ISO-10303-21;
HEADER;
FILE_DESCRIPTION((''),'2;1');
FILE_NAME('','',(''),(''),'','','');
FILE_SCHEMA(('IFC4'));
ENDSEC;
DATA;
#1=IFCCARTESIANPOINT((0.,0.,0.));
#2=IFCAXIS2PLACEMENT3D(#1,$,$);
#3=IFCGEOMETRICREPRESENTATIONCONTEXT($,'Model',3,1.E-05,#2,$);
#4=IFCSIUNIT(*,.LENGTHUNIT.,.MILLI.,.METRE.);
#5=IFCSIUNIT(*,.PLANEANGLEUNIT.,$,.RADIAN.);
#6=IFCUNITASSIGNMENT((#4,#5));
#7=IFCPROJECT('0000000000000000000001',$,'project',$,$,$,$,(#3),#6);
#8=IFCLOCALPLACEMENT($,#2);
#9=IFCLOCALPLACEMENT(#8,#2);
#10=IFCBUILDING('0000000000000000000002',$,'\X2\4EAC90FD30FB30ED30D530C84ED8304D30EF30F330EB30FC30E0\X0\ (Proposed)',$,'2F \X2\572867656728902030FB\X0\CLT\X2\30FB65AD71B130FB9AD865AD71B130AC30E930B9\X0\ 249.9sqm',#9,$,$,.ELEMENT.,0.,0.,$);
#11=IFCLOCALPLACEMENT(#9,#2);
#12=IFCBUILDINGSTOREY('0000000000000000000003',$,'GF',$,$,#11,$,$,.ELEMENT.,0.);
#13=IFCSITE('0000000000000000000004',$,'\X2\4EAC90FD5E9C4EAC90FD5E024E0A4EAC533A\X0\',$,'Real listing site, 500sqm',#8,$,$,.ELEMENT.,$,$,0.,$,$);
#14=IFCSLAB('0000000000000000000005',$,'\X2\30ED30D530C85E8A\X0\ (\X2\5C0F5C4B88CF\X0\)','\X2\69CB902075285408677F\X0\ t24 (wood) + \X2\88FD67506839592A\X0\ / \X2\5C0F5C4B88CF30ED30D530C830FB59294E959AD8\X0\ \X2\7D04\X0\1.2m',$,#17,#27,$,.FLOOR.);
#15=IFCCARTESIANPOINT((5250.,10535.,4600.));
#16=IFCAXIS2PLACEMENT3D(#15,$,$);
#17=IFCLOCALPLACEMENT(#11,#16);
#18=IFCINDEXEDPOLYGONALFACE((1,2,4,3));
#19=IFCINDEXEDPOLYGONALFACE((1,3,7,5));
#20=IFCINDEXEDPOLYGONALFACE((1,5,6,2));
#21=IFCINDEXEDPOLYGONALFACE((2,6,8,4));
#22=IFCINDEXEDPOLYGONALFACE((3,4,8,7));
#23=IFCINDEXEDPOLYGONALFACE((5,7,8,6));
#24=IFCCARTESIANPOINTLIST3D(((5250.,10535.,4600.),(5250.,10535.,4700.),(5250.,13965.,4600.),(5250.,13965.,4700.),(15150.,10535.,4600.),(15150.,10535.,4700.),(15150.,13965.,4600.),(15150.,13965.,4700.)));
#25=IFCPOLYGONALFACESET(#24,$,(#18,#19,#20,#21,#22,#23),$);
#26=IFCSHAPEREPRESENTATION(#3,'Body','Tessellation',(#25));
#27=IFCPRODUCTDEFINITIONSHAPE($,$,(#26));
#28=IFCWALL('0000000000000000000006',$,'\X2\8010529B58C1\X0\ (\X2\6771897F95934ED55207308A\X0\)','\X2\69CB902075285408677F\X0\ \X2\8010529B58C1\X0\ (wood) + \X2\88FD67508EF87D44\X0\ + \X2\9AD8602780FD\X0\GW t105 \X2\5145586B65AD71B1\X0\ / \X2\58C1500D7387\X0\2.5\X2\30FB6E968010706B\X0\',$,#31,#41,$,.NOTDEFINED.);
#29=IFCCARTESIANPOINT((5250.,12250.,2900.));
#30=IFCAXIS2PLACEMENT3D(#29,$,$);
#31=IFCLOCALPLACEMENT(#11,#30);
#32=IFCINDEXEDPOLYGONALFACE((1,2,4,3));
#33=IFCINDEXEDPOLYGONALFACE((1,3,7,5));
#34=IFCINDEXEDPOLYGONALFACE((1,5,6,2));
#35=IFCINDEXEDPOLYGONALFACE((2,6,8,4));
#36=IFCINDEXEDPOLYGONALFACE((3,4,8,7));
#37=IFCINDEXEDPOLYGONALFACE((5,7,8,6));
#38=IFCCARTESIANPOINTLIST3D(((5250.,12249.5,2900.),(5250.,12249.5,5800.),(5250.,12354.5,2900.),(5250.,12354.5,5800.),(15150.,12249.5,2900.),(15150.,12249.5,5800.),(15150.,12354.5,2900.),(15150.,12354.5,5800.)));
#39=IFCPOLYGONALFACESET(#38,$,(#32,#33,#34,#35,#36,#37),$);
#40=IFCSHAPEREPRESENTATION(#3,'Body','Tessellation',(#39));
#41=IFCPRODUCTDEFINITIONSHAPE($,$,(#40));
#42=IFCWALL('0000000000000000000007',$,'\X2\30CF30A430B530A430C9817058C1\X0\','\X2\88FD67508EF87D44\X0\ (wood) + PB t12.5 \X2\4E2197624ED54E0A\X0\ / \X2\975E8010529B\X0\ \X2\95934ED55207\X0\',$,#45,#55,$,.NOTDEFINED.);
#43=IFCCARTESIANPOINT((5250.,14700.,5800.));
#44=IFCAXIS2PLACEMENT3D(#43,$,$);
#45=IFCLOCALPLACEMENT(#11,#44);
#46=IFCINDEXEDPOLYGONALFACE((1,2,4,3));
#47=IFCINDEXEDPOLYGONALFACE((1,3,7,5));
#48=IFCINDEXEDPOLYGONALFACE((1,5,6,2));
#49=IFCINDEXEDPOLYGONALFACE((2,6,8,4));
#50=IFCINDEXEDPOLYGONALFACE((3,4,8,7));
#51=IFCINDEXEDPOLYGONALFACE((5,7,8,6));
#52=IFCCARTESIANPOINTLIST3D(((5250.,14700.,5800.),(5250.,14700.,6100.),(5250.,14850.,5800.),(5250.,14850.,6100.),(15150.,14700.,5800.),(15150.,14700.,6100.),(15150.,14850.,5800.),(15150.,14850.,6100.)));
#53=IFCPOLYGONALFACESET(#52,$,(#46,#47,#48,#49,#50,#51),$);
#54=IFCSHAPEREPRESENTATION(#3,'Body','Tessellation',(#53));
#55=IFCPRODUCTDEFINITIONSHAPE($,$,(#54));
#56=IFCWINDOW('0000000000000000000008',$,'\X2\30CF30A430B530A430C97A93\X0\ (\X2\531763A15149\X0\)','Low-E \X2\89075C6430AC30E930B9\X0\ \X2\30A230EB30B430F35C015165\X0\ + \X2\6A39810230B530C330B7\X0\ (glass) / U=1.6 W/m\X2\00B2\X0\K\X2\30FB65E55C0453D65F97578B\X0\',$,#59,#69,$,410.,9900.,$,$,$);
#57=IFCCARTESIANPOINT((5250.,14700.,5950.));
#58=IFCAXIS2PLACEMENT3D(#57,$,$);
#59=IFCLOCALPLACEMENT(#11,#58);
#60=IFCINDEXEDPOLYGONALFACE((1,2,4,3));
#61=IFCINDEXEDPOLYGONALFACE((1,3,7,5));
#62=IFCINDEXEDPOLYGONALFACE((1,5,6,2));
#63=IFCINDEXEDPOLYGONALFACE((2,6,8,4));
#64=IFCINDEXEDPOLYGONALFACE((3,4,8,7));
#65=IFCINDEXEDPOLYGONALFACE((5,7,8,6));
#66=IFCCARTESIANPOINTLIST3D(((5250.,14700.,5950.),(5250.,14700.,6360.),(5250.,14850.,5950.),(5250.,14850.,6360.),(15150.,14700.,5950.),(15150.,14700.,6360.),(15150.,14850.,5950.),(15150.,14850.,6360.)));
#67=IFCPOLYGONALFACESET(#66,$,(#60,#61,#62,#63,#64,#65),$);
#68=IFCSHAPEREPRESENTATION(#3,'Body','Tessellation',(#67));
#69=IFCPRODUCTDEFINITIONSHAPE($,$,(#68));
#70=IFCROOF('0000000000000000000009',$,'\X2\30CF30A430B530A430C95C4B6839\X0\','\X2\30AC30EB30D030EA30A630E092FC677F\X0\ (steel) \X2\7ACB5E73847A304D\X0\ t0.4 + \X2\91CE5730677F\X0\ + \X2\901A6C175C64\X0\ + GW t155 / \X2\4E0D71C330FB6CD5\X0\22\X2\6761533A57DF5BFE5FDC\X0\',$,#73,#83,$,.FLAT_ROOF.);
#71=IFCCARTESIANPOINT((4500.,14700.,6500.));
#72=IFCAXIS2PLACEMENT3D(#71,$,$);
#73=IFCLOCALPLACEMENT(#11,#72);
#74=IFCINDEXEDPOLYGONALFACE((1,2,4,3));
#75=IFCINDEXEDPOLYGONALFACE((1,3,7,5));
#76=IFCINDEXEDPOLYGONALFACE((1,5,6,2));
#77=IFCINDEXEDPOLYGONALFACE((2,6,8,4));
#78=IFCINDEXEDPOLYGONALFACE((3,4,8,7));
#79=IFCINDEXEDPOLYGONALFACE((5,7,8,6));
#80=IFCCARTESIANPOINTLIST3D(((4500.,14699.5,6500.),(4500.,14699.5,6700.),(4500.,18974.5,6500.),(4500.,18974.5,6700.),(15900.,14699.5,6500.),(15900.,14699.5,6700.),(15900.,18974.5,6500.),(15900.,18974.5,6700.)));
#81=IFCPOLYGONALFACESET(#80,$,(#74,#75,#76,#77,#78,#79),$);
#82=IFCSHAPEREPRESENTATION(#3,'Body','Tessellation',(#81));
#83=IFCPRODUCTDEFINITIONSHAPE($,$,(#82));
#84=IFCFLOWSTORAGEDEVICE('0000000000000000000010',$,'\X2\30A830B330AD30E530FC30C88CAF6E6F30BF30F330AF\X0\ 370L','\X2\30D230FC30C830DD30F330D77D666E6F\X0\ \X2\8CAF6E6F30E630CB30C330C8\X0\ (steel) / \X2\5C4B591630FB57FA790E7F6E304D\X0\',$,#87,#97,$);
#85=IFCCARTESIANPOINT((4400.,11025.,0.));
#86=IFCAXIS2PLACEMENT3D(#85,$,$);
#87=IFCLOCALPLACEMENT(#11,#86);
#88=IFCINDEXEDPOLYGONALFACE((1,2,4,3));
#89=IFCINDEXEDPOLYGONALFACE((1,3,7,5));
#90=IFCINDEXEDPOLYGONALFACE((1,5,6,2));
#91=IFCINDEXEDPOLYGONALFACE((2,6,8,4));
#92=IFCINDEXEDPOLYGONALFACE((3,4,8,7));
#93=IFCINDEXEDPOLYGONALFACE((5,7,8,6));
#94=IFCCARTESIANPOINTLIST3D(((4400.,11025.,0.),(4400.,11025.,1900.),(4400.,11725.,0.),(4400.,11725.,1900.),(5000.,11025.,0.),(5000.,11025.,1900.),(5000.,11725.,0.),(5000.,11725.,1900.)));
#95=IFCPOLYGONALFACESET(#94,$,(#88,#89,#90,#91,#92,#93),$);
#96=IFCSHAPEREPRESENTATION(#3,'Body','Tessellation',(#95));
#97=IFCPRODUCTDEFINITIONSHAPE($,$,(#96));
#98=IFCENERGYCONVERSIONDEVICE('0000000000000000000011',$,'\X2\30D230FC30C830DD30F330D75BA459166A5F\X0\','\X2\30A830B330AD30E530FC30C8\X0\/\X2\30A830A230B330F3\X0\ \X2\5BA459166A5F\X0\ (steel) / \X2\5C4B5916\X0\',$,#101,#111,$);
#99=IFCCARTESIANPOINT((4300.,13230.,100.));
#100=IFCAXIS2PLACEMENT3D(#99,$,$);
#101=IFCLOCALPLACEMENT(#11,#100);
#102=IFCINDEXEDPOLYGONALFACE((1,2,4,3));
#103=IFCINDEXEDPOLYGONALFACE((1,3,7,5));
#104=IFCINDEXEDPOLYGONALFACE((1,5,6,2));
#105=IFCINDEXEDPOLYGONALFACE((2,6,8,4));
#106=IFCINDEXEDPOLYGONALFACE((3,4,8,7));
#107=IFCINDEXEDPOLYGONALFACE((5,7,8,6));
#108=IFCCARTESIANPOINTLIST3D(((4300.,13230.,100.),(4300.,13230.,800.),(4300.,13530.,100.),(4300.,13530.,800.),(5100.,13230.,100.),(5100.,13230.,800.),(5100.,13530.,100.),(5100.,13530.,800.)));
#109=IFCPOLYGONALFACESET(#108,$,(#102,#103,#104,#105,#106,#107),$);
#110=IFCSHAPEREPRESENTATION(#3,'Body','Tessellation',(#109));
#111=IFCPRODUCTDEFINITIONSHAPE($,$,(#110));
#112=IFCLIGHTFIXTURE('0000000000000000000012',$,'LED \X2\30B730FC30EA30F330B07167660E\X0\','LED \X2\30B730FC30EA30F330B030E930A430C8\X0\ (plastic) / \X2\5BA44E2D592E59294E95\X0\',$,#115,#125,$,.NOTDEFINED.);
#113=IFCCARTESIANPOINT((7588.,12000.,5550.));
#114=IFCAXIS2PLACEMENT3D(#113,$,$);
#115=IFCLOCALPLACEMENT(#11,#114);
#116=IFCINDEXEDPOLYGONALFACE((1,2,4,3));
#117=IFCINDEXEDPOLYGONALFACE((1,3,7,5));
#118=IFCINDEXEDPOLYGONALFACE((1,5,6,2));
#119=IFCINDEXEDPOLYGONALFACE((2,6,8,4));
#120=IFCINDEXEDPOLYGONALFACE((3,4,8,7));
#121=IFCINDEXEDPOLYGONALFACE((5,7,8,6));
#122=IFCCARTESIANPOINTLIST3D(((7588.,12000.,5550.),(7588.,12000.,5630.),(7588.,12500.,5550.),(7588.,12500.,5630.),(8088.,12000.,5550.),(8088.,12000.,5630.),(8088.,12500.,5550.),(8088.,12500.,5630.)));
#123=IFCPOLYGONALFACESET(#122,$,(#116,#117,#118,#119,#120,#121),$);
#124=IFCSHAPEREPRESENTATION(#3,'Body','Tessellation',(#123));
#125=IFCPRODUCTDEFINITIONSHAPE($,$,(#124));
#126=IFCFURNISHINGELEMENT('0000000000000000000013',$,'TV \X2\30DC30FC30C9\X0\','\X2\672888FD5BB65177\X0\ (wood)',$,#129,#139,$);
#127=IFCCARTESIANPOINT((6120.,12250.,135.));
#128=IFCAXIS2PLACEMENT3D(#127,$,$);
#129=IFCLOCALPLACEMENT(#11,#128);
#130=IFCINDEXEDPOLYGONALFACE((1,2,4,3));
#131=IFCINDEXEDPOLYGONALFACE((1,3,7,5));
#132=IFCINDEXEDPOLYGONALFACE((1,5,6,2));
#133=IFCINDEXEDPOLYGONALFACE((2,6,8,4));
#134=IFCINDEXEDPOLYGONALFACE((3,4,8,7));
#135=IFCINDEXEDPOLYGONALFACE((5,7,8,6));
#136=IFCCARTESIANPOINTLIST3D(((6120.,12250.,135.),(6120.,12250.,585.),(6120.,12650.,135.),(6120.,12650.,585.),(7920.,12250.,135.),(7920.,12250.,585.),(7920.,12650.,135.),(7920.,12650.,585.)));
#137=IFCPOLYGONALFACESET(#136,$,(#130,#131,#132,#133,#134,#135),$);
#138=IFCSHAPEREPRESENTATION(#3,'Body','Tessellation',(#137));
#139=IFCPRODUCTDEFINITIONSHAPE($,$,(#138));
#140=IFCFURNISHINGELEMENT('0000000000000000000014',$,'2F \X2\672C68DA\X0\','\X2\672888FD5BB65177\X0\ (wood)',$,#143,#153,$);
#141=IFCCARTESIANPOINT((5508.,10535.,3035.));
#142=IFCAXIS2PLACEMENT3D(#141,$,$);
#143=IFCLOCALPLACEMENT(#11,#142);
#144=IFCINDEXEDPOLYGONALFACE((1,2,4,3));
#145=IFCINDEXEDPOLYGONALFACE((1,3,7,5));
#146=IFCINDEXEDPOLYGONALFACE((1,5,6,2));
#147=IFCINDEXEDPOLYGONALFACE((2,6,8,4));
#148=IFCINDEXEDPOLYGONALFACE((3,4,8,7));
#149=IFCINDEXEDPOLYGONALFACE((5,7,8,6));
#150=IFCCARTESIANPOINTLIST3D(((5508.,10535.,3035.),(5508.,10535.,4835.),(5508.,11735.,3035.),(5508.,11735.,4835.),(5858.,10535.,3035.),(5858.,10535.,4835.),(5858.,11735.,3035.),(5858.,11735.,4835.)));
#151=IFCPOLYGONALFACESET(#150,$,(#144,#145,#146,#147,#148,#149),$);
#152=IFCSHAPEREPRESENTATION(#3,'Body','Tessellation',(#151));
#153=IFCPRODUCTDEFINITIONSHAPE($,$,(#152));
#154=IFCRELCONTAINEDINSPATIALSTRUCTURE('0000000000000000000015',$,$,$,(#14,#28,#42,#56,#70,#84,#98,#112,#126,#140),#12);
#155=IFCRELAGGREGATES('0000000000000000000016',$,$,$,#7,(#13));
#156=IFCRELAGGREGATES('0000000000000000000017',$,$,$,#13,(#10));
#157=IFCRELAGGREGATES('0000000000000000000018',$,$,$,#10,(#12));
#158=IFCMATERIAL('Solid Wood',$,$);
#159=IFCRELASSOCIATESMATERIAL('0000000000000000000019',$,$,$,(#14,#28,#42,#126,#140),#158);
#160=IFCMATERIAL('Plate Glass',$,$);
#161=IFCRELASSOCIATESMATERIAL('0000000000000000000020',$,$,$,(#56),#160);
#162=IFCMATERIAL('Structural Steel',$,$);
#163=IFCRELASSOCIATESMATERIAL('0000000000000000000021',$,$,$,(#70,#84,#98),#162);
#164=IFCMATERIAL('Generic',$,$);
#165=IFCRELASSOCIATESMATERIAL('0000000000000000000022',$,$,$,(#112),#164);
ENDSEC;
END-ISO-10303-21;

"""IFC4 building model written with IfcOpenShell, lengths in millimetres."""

from ifc_helpers import new_model, si_unit, frame, frame_2d, origin, place, context, project, spatial, rectangle, extrude, material, element, fill, save


model = new_model("IFC4")

# Units and contexts
model_context = context("Model", 3, precision=1e-05, world=origin())
ifc_project = project(units=[si_unit("LENGTHUNIT", "METRE", prefix="MILLI"), si_unit("PLANEANGLEUNIT", "RADIAN")], contexts=[model_context])

# Site, building, storey
site_placement = place(None, origin())
site = spatial("IfcSite", under=ifc_project, at=site_placement, Name="京都府京都市上京区", ObjectType="Real listing site, 500sqm", CompositionType="ELEMENT", RefElevation=0.0)
building_placement = place(site_placement, origin())
building = spatial("IfcBuilding", under=site, at=building_placement, Name="京都・ロフト付きワンルーム (Proposed)", ObjectType="2F 在来木造・CLT・断熱・高断熱ガラス 249.9sqm", CompositionType="ELEMENT", ElevationOfRefHeight=0.0, ElevationOfTerrain=0.0)
storey_placement = place(building_placement, origin())
storey = spatial("IfcBuildingStorey", under=building, at=storey_placement, Name="GF", CompositionType="ELEMENT", Elevation=0.0)

# Shared definitions
ifc_material_1 = material(Name="Solid Wood")

# Slab
slab_placement = place(storey_placement, frame((5250.0, 10535.0, 4600.0)))
element("IfcSlab", 1, at=slab_placement, inside=storey, material=ifc_material_1, Name="ロフト床 (小屋裏)", Description="構造用合板 t24 (wood) + 製材根太 / 小屋裏ロフト・天井高 約1.2m", PredefinedType="FLOOR", context=model_context, shape_type="SweptSolid", body=[
    extrude(rectangle(XDim=9900.0, YDim=3430.0, at=frame_2d((4950.0, 1715.0))), frame((5250.0, 10535.0, 4600.0)), (0.0, 0.0, 1.0), 100.0),
])

# Wall
wall_1_placement = place(storey_placement, frame((5250.0, 12250.0, 2900.0)))
element("IfcWall", 2, at=wall_1_placement, inside=storey, material=ifc_material_1, Name="耐力壁 (東西間仕切り)", Description="構造用合板 耐力壁 (wood) + 製材軸組 + 高性能GW t105 充填断熱 / 壁倍率2.5・準耐火", PredefinedType="NOTDEFINED", context=model_context, shape_type="SweptSolid", body=[
    extrude(rectangle(XDim=9900.0, YDim=105.0, at=frame_2d((4950.0, 52.0))), frame((5250.0, 12250.0, 2900.0)), (0.0, 0.0, 1.0), 2900.0),
])

# Wall, opening, window
wall_2_placement = place(storey_placement, frame((5250.0, 14700.0, 5800.0)))
wall_2 = element("IfcWall", 3, at=wall_2_placement, inside=storey, material=ifc_material_1, Name="ハイサイド腰壁", Description="製材軸組 (wood) + PB t12.5 両面仕上 / 非耐力 間仕切", PredefinedType="NOTDEFINED", context=model_context, shape_type="SweptSolid", body=[
    extrude(rectangle(XDim=9900.0, YDim=150.0, at=frame_2d((4950.0, 75.0))), frame((5250.0, 14700.0, 5800.0)), (0.0, 0.0, 1.0), 700.0),
])
opening_1_placement = place(storey_placement, frame((5250.0, 14700.0, 5950.0)))
opening_1 = element("IfcOpeningElement", 4, at=opening_1_placement, cuts=wall_2, PredefinedType="NOTDEFINED", context=model_context, shape_type="SweptSolid", body=[
    extrude(rectangle(XDim=9900.0, YDim=150.0, at=frame_2d((4950.0, 75.0))), frame((5250.0, 14700.0, 5950.0)), (0.0, 0.0, 1.0), 410.0),
])
ifc_material_2 = material(Name="Plate Glass")
window_placement = place(storey_placement, frame((5250.0, 14700.0, 5950.0)))
window = element("IfcWindow", 5, at=window_placement, inside=storey, material=ifc_material_2, Name="ハイサイド窓 (北採光)", Description="Low-E 複層ガラス アルゴン封入 + 樹脂サッシ (glass) / U=1.6 W/m²K・日射取得型", OverallHeight=410.0, OverallWidth=9900.0, context=model_context, shape_type="SweptSolid", body=[
    extrude(rectangle(XDim=9900.0, YDim=150.0, at=frame_2d((4950.0, 75.0))), frame((5250.0, 14700.0, 5950.0)), (0.0, 0.0, 1.0), 410.0),
])
fill(opening_1, window)

# Roof
ifc_material_3 = material(Name="Structural Steel")
roof_placement = place(storey_placement, frame((4500.0, 14700.0, 6500.0)))
element("IfcRoof", 6, at=roof_placement, inside=storey, material=ifc_material_3, Name="ハイサイド屋根", Description="ガルバリウム鋼板 (steel) 立平葺き t0.4 + 野地板 + 通気層 + GW t155 / 不燃・法22条区域対応", PredefinedType="FLAT_ROOF", context=model_context, shape_type="SweptSolid", body=[
    extrude(rectangle(XDim=11400.0, YDim=4275.0, at=frame_2d((5700.0, 2137.0))), frame((4500.0, 14700.0, 6500.0)), (0.0, 0.0, 1.0), 200.0),
])

# Flow storage device
flow_storage_device_placement = place(storey_placement, frame((4400.0, 11025.0, 0.0)))
element("IfcFlowStorageDevice", 7, at=flow_storage_device_placement, inside=storey, material=ifc_material_3, Name="エコキュート貯湯タンク 370L", Description="ヒートポンプ給湯 貯湯ユニット (steel) / 屋外・基礎置き", context=model_context, shape_type="SweptSolid", body=[
    extrude(rectangle(XDim=600.0, YDim=700.0, at=frame_2d((300.0, 350.0))), frame((4400.0, 11025.0, 0.0)), (0.0, 0.0, 1.0), 1900.0),
])

# Energy conversion device
energy_conversion_device_placement = place(storey_placement, frame((4300.0, 13230.0, 100.0)))
element("IfcEnergyConversionDevice", 8, at=energy_conversion_device_placement, inside=storey, material=ifc_material_3, Name="ヒートポンプ室外機", Description="エコキュート/エアコン 室外機 (steel) / 屋外", context=model_context, shape_type="SweptSolid", body=[
    extrude(rectangle(XDim=800.0, YDim=300.0, at=frame_2d((400.0, 150.0))), frame((4300.0, 13230.0, 100.0)), (0.0, 0.0, 1.0), 700.0),
])

# Light fixture
ifc_material_4 = material(Name="Generic")
light_fixture_placement = place(storey_placement, frame((7588.0, 12000.0, 5550.0)))
element("IfcLightFixture", 9, at=light_fixture_placement, inside=storey, material=ifc_material_4, Name="LED シーリング照明", Description="LED シーリングライト (plastic) / 室中央天井", PredefinedType="NOTDEFINED", context=model_context, shape_type="SweptSolid", body=[
    extrude(rectangle(XDim=500.0, YDim=500.0, at=frame_2d((250.0, 250.0))), frame((7588.0, 12000.0, 5550.0)), (0.0, 0.0, 1.0), 80.0),
])

# Furnishing elements
furnishing_1_placement = place(storey_placement, frame((6120.0, 12250.0, 135.0)))
element("IfcFurnishingElement", 10, at=furnishing_1_placement, inside=storey, material=ifc_material_1, Name="TV ボード", Description="木製家具 (wood)", context=model_context, shape_type="SweptSolid", body=[
    extrude(rectangle(XDim=1800.0, YDim=400.0, at=frame_2d((900.0, 200.0))), frame((6120.0, 12250.0, 135.0)), (0.0, 0.0, 1.0), 450.0),
])
furnishing_2_placement = place(storey_placement, frame((5508.0, 10535.0, 3035.0)))
element("IfcFurnishingElement", 11, at=furnishing_2_placement, inside=storey, material=ifc_material_1, Name="2F 本棚", Description="木製家具 (wood)", context=model_context, shape_type="SweptSolid", body=[
    extrude(rectangle(XDim=350.0, YDim=1200.0, at=frame_2d((175.0, 600.0))), frame((5508.0, 10535.0, 3035.0)), (0.0, 0.0, 1.0), 1800.0),
])

save(model, "model.ifc")
